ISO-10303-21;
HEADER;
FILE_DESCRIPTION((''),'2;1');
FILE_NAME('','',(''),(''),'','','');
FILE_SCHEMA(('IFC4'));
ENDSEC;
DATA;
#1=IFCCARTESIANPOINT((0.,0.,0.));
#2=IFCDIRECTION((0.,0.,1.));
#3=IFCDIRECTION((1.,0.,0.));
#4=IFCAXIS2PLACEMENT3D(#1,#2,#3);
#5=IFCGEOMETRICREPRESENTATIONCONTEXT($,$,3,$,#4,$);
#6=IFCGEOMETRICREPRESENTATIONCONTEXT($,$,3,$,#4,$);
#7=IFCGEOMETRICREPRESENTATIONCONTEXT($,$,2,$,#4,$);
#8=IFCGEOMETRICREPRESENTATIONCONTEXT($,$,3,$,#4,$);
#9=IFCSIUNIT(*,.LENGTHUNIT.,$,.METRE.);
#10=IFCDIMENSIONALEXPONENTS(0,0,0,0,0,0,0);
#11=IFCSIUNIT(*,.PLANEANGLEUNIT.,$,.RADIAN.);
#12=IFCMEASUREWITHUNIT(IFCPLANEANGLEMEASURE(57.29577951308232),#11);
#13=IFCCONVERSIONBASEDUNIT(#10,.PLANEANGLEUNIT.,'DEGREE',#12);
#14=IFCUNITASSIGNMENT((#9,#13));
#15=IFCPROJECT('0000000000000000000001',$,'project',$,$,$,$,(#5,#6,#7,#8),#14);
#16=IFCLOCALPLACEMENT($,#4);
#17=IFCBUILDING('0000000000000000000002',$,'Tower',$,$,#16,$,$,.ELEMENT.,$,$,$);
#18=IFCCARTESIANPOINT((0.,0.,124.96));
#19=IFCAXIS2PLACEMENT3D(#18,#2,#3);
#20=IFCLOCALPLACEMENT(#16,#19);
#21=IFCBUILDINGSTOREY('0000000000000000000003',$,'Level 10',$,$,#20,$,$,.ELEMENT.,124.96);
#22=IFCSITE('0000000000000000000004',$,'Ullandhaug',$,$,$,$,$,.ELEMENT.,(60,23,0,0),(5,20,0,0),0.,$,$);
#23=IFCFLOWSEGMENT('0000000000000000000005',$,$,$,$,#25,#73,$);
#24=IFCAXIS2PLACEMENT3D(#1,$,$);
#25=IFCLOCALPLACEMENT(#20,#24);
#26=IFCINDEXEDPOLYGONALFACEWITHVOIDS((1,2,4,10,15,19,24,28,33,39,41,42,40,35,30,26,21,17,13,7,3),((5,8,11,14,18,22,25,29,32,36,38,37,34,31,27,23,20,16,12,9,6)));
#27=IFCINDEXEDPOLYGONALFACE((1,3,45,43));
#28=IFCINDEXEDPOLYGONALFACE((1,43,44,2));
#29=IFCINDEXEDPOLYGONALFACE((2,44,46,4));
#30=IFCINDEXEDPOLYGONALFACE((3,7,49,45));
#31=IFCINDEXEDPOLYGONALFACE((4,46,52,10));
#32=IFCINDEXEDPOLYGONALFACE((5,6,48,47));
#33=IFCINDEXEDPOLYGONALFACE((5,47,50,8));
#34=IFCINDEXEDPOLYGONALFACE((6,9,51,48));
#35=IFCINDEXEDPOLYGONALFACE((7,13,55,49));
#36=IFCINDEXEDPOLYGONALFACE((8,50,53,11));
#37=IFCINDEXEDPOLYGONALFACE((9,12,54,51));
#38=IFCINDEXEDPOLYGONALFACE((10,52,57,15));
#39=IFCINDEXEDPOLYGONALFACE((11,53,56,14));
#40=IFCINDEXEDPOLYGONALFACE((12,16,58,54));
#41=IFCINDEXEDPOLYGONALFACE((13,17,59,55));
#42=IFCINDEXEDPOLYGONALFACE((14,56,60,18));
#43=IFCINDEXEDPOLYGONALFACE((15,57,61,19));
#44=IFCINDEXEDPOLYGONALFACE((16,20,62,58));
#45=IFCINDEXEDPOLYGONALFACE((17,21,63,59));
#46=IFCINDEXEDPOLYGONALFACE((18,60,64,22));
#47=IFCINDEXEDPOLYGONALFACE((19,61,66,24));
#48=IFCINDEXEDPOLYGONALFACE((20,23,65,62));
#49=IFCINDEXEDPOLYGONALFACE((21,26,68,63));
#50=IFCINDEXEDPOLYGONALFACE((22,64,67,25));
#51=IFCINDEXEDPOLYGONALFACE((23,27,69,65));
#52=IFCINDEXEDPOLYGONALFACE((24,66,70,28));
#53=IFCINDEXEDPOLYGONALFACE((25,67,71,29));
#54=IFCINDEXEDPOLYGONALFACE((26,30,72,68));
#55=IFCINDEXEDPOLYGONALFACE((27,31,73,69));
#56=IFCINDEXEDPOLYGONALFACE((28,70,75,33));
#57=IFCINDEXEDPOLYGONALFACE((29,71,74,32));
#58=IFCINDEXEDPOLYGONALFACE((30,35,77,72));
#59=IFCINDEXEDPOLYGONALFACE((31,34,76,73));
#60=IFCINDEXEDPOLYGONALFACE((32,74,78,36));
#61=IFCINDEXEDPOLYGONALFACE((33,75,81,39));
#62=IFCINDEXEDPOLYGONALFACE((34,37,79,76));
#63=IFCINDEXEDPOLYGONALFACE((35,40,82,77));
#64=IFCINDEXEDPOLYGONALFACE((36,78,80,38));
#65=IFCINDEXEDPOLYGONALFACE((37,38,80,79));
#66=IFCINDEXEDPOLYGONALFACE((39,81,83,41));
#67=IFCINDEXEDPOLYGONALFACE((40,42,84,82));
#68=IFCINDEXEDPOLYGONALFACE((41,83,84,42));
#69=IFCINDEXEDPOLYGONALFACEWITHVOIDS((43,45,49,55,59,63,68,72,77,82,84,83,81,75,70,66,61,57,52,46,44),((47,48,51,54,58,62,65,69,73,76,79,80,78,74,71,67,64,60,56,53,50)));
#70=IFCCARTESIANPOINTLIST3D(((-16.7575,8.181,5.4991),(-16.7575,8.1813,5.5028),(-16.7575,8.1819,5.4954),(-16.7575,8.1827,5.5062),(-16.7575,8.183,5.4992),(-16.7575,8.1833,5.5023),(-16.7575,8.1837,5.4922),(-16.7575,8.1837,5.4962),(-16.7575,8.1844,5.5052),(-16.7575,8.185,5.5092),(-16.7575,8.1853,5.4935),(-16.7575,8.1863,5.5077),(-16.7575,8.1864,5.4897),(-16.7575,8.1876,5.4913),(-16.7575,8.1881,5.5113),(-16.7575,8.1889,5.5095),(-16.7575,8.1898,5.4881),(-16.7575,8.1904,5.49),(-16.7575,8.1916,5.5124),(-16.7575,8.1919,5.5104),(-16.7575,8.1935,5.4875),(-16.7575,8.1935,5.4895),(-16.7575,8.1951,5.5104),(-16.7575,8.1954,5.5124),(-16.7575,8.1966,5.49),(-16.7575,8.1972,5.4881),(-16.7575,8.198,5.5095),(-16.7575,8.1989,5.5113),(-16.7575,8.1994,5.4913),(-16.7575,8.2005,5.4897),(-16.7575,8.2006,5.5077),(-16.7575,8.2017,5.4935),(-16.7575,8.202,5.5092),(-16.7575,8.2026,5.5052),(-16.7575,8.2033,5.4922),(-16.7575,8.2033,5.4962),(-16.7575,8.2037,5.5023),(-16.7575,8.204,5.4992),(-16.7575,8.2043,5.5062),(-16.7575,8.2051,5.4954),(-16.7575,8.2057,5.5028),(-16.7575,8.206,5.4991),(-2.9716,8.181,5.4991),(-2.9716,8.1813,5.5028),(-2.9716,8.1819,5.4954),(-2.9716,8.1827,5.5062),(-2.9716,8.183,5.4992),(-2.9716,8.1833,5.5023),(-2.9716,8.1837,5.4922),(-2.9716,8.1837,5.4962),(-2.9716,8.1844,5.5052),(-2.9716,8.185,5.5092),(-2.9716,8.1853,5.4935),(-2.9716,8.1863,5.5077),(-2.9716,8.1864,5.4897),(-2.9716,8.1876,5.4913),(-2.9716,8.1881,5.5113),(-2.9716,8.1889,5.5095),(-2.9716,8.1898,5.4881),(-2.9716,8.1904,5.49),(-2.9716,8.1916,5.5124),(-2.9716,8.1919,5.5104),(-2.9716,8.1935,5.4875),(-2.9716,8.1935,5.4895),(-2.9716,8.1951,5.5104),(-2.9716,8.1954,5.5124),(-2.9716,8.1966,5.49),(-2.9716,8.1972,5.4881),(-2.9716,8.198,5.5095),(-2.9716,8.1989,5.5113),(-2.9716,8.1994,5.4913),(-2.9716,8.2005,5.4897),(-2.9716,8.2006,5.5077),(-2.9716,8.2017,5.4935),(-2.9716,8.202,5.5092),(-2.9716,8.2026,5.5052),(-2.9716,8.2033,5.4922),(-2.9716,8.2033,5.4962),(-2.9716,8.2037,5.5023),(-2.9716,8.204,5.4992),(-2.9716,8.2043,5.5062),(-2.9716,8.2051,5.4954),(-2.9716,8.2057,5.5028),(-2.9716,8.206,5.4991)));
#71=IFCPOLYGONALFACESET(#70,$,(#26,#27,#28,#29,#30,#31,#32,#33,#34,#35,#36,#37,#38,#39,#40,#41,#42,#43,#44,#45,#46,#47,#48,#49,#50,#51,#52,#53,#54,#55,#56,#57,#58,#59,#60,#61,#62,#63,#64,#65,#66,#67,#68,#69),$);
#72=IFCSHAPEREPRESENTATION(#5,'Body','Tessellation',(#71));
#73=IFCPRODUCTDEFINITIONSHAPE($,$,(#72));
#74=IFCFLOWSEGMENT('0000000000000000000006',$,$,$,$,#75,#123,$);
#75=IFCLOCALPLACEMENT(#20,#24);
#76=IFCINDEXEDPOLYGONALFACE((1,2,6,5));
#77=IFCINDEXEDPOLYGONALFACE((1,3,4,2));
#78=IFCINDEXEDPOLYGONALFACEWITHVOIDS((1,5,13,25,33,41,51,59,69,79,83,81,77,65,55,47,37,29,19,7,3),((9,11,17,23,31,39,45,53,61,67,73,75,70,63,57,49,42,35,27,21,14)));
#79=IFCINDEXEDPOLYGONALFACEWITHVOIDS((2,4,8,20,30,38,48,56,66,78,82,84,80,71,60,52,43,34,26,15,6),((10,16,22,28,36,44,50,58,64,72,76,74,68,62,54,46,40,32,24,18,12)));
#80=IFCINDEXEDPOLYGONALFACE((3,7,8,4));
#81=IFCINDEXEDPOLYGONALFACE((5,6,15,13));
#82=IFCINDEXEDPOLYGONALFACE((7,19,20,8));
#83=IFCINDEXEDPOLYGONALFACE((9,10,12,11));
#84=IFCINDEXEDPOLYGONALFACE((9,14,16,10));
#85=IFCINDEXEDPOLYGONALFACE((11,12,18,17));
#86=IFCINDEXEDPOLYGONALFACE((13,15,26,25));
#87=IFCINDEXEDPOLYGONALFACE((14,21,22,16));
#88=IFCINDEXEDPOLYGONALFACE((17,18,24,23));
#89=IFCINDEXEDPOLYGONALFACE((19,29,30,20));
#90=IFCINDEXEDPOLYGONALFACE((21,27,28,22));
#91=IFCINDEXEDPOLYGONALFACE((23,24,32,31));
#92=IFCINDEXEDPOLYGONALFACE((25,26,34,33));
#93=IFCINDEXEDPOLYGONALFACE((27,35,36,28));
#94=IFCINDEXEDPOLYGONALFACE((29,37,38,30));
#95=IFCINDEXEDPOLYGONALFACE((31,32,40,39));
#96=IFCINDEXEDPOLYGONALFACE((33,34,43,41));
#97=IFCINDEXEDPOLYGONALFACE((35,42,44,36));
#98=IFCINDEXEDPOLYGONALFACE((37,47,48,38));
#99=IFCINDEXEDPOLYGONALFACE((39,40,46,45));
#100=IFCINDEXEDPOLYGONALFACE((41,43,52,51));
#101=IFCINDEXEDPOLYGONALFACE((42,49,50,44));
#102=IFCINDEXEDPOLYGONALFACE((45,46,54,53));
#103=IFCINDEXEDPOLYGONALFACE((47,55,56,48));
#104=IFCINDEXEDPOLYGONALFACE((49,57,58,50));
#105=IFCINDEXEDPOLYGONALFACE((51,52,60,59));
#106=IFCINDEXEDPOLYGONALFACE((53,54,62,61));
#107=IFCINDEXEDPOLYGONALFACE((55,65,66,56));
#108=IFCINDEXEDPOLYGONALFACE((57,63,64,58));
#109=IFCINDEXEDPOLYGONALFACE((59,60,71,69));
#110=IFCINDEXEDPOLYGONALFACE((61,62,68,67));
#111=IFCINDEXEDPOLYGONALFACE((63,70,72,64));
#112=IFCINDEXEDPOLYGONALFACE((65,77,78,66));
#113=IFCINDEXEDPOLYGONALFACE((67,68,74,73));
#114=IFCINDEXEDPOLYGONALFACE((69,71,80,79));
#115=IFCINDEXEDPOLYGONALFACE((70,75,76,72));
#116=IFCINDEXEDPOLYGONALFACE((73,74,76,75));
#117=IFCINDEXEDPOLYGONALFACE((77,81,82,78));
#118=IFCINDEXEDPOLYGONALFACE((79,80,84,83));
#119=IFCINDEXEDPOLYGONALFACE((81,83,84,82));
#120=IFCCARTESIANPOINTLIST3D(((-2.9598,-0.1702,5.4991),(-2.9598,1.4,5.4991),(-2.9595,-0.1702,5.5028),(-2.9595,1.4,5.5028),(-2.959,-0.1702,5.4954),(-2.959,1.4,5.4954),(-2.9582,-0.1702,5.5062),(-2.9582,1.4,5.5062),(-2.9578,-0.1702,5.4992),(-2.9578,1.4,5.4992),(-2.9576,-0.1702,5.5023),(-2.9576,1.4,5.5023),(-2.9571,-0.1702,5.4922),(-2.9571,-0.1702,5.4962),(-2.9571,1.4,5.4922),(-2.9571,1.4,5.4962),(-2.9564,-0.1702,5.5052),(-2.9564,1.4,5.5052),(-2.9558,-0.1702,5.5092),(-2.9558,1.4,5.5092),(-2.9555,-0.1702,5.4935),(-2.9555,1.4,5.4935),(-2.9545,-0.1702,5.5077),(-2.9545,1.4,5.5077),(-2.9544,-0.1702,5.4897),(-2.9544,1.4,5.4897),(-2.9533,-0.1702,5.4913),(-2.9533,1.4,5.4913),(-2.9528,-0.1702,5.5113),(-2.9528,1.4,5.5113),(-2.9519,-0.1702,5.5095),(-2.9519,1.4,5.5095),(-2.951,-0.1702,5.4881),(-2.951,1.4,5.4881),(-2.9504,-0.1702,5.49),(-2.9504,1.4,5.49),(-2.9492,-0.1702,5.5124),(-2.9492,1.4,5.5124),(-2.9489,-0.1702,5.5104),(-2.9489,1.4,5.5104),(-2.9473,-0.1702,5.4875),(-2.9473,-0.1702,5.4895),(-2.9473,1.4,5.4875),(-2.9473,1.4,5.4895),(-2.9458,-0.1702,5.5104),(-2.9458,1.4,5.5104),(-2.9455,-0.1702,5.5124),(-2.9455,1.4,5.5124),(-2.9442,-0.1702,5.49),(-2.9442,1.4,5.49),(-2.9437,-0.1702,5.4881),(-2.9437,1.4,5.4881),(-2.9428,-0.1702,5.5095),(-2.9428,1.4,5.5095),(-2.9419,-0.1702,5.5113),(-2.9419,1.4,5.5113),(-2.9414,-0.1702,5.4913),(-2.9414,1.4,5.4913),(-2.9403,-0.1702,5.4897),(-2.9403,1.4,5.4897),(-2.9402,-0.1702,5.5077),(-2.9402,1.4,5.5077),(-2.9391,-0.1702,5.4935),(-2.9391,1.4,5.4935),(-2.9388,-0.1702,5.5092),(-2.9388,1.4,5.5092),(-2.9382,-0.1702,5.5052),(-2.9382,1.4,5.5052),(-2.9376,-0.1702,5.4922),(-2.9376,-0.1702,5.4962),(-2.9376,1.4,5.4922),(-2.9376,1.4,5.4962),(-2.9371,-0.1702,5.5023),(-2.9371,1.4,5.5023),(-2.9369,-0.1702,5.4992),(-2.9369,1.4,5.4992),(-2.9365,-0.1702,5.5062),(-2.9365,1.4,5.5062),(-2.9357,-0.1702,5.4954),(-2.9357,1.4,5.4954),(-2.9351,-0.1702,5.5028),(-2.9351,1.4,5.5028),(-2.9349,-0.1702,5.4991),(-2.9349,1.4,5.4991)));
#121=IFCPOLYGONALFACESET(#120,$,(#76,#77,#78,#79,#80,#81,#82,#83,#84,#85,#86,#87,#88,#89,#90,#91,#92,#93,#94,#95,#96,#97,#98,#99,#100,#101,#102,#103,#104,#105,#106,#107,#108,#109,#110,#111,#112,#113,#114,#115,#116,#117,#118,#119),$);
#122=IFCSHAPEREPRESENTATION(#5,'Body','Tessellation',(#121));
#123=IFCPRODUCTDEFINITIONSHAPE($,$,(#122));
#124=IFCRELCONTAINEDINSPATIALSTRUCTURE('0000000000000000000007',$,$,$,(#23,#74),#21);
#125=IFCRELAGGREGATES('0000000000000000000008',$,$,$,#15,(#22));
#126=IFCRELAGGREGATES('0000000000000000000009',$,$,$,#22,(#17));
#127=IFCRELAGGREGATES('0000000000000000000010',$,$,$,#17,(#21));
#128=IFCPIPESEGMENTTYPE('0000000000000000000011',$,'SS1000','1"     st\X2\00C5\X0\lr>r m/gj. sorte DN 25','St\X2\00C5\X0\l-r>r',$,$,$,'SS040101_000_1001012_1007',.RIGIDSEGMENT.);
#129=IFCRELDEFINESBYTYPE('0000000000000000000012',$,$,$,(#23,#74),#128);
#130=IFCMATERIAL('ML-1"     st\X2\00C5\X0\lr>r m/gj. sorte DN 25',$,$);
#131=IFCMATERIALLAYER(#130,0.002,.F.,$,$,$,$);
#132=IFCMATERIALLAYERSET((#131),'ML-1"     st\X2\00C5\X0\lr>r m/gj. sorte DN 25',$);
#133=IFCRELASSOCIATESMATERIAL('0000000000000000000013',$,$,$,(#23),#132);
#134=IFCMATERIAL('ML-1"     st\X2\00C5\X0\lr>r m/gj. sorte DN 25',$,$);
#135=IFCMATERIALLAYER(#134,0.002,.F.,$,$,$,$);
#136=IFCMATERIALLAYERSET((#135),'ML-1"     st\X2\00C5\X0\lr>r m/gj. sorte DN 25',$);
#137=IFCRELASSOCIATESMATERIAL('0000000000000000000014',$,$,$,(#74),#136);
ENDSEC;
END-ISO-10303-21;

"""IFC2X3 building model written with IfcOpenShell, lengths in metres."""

from ifc_helpers import new_model, entity, si_unit, converted_unit, frame, origin_with_axes, origin_2d_with_axis, place, context, project, spatial, hollow_circle, extrude, material, layer, layer_set, layer_usage, type_object, element, save


model = new_model("IFC2X3")

# Units and contexts
context_of_model_1 = context(None, 3, world=origin_with_axes())
context_of_model_2 = context(None, 3, world=origin_with_axes())
context_of_model_3 = context(None, 2, world=origin_with_axes())
context_of_model_4 = context(None, 3, world=origin_with_axes())
ifc_project = project(units=[si_unit("LENGTHUNIT", "METRE"), converted_unit("PLANEANGLEUNIT", "DEGREE", entity("IfcPlaneAngleMeasure", 57.29577951308232), si_unit("PLANEANGLEUNIT", "RADIAN"), dimensions=[0, 0, 0, 0, 0, 0, 0])], contexts=[context_of_model_1, context_of_model_2, context_of_model_3, context_of_model_4])

# Site, building, storey
site = spatial("IfcSite", under=ifc_project, Name="Ullandhaug", CompositionType="ELEMENT", RefLatitude=(60, 23, 0, 0), RefLongitude=(5, 20, 0, 0), RefElevation=0.0)
building_placement = place(None, origin_with_axes())
building = spatial("IfcBuilding", under=site, at=building_placement, Name="Tower", CompositionType="ELEMENT")
storey_placement = place(building_placement, frame((0.0, 0.0, 124.96), z_axis=(0.0, 0.0, 1.0), x_axis=(1.0, 0.0, 0.0)))
storey = spatial("IfcBuildingStorey", under=building, at=storey_placement, Name="Level 10", CompositionType="ELEMENT", Elevation=124.96)

# Flow segments
pipe_segment_type_1 = type_object("IfcPipeSegmentType", Name="SS1000", Description="1\"     stÅlr>r m/gj. sorte DN 25", ApplicableOccurrence="StÅl-r>r", ElementType="SS040101_000_1001012_1007", PredefinedType="RIGIDSEGMENT")
ifc_material_1 = material(Name="ML-1\"     stÅlr>r m/gj. sorte DN 25")
ifc_layer_1 = layer(ifc_material_1, 0.002, ventilated=False)
ifc_layer_set_1 = layer_set([ifc_layer_1], Name="ML-1\"     stÅlr>r m/gj. sorte DN 25")
ifc_layer_usage_1 = layer_usage(ifc_layer_set_1, "AXIS2", "POSITIVE", 0.0)
flow_segment_1_placement = place(storey_placement, frame((-2.9716, 8.1935, 5.5), z_axis=(-1.0, 0.0, 0.0), x_axis=(0.0, 0.0, -1.0)))
element("IfcFlowSegment", 1, at=flow_segment_1_placement, inside=storey, type_object=pipe_segment_type_1, material=ifc_layer_usage_1, context=context_of_model_1, shape_type="SweptSolid", body=[
    extrude(hollow_circle(Radius=0.0125, WallThickness=0.002, at=origin_2d_with_axis()), origin_with_axes(), (0.0, 0.0, 1.0), 13.7859),
])
ifc_material_2 = material(Name="ML-1\"     stÅlr>r m/gj. sorte DN 25")
ifc_layer_2 = layer(ifc_material_2, 0.002, ventilated=False)
ifc_layer_set_2 = layer_set([ifc_layer_2], Name="ML-1\"     stÅlr>r m/gj. sorte DN 25")
ifc_layer_usage_2 = layer_usage(ifc_layer_set_2, "AXIS2", "POSITIVE", 0.0)
flow_segment_2_placement = place(storey_placement, frame((-2.9473, -0.1702, 5.5), z_axis=(0.0, 1.0, 0.0), x_axis=(0.0, 0.0, -1.0)))
element("IfcFlowSegment", 2, at=flow_segment_2_placement, inside=storey, type_object=pipe_segment_type_1, material=ifc_layer_usage_2, context=context_of_model_1, shape_type="SweptSolid", body=[
    extrude(hollow_circle(Radius=0.0125, WallThickness=0.002, at=origin_2d_with_axis()), origin_with_axes(), (0.0, 0.0, 1.0), 1.5702),
])

save(model, "model.ifc")
